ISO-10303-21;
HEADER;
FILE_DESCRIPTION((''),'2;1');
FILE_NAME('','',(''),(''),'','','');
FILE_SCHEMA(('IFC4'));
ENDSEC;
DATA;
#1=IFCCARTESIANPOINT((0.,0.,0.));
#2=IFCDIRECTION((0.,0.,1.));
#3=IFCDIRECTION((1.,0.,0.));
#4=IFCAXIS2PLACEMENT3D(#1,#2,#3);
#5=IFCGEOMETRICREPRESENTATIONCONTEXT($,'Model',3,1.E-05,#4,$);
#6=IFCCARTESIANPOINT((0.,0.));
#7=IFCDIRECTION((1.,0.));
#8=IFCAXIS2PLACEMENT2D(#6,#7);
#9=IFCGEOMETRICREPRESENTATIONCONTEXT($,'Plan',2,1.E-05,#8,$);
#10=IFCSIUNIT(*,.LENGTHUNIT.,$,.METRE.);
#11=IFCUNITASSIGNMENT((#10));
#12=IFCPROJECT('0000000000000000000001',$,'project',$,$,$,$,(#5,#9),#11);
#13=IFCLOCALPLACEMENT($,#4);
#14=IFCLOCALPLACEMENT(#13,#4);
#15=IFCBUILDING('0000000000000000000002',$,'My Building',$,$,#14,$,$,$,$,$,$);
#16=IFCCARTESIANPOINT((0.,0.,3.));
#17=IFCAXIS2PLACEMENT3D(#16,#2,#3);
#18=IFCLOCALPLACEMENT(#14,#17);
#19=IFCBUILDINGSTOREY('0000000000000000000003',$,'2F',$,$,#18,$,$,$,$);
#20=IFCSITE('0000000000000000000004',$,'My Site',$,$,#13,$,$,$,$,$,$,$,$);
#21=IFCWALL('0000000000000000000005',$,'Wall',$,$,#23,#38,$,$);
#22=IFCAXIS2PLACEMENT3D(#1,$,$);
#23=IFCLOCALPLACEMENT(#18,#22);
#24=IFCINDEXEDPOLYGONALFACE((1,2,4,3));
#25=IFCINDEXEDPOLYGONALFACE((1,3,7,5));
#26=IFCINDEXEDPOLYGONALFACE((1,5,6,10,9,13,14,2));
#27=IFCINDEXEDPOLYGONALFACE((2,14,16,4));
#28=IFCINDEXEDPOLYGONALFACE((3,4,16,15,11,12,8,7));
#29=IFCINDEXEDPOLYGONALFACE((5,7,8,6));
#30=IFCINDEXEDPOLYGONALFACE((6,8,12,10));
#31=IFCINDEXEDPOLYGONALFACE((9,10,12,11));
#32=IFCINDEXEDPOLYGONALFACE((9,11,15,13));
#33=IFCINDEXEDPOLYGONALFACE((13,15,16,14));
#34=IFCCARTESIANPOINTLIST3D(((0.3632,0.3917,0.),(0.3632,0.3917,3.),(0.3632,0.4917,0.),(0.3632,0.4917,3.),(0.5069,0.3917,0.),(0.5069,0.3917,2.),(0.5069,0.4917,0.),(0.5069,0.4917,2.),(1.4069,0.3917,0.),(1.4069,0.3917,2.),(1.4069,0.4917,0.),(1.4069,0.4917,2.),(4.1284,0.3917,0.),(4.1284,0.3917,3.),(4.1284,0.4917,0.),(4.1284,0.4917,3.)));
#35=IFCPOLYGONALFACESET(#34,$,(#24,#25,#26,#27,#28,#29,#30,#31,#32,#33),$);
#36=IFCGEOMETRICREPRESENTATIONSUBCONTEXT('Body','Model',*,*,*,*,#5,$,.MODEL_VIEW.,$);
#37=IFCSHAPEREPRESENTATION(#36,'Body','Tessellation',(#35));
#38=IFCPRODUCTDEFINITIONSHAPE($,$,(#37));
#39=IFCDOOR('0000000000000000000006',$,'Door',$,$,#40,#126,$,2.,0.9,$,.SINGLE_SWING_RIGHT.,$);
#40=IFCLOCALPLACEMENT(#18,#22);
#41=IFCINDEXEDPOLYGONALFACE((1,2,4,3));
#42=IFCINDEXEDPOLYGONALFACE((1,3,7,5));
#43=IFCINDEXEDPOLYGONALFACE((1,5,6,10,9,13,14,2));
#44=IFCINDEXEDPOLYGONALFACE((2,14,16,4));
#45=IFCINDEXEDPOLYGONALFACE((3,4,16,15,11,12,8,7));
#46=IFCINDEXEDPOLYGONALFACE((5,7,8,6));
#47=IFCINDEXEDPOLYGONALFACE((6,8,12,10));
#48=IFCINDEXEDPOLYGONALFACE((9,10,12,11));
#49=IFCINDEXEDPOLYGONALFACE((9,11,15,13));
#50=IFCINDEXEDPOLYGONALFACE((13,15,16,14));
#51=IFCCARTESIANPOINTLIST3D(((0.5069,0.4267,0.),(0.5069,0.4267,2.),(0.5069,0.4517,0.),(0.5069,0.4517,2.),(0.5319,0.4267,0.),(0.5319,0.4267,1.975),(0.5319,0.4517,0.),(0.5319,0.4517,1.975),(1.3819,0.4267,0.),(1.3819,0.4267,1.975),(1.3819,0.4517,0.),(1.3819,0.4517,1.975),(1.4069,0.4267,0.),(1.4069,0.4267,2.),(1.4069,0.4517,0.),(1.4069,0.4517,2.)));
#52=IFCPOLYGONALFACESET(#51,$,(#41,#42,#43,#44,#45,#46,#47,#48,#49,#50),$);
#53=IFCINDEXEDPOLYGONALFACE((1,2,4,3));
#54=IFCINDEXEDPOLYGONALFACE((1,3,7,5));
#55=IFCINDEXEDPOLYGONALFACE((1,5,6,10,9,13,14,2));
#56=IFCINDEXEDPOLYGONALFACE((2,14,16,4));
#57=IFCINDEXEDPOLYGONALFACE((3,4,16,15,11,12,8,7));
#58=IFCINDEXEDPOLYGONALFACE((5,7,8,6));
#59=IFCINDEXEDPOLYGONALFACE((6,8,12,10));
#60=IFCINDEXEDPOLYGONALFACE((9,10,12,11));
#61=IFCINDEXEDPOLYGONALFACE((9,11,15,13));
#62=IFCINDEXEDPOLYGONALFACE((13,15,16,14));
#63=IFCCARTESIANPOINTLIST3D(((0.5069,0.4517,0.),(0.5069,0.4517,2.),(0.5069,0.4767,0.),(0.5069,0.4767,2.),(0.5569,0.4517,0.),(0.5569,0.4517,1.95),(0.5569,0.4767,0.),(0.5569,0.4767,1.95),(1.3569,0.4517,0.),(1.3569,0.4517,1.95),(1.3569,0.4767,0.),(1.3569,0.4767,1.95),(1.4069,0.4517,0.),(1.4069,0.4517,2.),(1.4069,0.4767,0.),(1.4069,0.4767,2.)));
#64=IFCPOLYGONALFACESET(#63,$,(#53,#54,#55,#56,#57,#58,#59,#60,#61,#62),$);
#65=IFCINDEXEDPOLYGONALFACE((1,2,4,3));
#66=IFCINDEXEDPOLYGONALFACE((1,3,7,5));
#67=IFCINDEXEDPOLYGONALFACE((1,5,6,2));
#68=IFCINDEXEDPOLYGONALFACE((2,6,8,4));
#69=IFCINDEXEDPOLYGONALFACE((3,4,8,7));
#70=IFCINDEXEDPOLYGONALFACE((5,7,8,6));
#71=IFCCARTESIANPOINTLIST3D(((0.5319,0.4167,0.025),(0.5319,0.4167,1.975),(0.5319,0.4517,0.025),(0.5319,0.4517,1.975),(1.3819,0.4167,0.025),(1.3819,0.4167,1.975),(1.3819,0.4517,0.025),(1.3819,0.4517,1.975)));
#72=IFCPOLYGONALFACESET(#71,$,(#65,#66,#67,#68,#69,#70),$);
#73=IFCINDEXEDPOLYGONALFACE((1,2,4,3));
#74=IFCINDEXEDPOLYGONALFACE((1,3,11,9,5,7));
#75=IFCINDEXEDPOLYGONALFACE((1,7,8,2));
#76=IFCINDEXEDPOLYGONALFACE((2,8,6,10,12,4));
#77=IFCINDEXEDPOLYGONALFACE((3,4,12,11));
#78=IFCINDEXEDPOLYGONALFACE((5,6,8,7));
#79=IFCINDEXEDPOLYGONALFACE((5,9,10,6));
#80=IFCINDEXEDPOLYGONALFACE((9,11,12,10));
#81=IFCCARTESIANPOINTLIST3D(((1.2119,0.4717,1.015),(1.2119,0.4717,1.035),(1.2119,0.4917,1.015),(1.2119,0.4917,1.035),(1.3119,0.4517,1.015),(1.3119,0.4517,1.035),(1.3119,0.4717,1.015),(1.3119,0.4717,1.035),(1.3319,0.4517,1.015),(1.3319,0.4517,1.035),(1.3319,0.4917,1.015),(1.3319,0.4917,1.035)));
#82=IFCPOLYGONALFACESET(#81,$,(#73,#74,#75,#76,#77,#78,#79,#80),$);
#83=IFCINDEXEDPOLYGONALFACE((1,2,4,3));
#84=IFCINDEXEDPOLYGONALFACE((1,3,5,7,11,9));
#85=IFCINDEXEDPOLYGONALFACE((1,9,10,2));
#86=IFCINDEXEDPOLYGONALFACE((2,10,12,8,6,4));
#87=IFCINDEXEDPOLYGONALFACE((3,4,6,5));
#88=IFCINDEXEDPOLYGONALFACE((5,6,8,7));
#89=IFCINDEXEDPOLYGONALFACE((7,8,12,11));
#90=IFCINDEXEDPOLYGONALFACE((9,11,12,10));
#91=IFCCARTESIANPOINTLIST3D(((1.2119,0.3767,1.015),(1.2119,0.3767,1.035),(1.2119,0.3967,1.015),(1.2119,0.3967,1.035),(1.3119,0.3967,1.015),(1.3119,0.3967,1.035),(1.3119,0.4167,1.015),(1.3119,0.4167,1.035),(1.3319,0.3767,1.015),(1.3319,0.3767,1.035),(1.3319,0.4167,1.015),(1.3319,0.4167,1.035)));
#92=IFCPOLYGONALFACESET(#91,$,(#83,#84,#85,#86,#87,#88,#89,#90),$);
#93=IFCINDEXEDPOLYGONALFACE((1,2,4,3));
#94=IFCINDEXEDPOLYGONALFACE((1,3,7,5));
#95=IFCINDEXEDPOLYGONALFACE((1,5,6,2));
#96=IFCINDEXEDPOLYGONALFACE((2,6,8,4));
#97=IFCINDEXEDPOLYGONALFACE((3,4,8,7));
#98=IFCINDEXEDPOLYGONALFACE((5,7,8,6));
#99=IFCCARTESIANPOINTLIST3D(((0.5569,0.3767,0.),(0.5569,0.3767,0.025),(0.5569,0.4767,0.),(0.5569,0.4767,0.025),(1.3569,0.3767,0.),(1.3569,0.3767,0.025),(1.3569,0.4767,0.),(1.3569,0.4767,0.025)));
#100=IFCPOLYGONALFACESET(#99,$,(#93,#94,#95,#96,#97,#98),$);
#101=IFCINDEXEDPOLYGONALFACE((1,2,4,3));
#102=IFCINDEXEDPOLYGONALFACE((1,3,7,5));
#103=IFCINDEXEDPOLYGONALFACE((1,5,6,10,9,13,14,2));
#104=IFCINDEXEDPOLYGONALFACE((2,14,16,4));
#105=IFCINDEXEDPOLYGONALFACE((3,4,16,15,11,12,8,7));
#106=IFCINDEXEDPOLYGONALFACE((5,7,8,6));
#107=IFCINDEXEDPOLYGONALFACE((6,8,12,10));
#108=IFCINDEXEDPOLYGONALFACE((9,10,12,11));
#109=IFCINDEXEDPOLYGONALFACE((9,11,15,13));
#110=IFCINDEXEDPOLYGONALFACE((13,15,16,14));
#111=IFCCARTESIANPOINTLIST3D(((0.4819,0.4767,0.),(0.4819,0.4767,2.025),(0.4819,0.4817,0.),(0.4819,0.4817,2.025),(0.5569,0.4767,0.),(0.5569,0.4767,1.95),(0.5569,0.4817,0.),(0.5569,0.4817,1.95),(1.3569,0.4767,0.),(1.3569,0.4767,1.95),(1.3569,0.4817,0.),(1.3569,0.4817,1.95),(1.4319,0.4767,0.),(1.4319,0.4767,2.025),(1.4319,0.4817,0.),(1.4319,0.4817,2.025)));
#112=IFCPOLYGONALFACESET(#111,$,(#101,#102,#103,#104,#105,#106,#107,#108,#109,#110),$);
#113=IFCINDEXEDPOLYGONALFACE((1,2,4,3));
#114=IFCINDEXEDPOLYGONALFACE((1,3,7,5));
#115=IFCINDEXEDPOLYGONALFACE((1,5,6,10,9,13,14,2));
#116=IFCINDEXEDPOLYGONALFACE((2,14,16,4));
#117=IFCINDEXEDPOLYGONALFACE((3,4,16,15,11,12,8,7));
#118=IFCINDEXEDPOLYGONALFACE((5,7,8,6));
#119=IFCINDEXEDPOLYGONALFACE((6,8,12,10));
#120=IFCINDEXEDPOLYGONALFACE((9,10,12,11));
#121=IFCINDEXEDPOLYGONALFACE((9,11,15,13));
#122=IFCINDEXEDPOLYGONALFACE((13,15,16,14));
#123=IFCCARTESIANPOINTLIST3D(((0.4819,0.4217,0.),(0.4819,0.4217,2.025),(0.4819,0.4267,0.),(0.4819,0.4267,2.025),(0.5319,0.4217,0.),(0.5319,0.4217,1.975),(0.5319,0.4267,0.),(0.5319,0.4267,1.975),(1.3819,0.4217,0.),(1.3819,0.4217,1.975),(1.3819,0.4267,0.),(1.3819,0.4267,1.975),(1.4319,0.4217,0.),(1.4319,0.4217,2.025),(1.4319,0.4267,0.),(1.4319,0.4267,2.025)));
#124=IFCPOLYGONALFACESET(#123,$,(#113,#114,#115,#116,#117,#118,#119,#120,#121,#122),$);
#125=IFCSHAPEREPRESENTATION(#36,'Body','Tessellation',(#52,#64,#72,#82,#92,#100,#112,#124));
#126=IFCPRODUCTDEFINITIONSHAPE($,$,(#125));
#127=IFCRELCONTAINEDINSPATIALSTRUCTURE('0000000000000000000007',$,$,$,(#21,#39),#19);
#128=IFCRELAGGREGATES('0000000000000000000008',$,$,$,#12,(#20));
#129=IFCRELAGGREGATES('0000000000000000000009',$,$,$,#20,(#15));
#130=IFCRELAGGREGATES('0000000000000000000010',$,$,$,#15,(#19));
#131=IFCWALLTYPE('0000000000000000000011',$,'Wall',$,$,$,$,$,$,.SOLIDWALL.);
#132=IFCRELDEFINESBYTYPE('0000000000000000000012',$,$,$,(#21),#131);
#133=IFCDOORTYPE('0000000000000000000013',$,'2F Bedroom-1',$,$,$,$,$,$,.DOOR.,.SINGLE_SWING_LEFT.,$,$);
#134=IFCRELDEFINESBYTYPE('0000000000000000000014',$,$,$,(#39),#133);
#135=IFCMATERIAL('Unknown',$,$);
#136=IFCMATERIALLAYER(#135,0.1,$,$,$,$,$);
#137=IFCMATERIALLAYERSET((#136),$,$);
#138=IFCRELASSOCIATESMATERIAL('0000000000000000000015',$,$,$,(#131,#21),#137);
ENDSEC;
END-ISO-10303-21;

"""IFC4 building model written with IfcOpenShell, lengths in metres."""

from ifc_helpers import new_model, entity, si_unit, frame, origin_with_axes, origin_2d_with_axis, place, context, subcontext, project, spatial, line, indexed_curve, outline, extrude, shape, source, transform, mapped, material, layer, layer_set, layer_usage, type_object, type_shapes, element, fill, save


model = new_model("IFC4")

# Units and contexts
model_context_1 = context("Model", 3, precision=1e-05, world=origin_with_axes())
plan_context = context("Plan", 2, precision=1e-05, world=origin_2d_with_axis())
body_context_1 = subcontext(model_context_1, "Body", "Model", "MODEL_VIEW")
body_context_2 = subcontext(plan_context, "Body", "Plan", "PLAN_VIEW")
ifc_project = project(units=[si_unit("LENGTHUNIT", "METRE")], contexts=[model_context_1, plan_context])

# Site, building, storey
site_placement = place(None, origin_with_axes())
site = spatial("IfcSite", under=ifc_project, at=site_placement, Name="My Site")
building_placement = place(site_placement, origin_with_axes())
building = spatial("IfcBuilding", under=site, at=building_placement, Name="My Building")
storey_placement = place(building_placement, frame((0.0, 0.0, 3.0), z_axis=(0.0, 0.0, 1.0), x_axis=(1.0, 0.0, 0.0)))
storey = spatial("IfcBuildingStorey", under=building, at=storey_placement, Name="2F")

# Shared definitions
ifc_material = material(Name="Unknown")

# Shared definitions
ifc_layer_1 = layer(ifc_material, 0.1)
ifc_layer_set_1 = layer_set([ifc_layer_1])
wall_type = type_object("IfcWallType", Name="Wall", PredefinedType="SOLIDWALL", material=ifc_layer_set_1)

# Wall, opening, door
ifc_layer_usage_1 = layer_usage(ifc_layer_set_1, "AXIS2", "POSITIVE", 0.0)
wall_1_placement = place(storey_placement, frame((4.1284, 0.4917, 0.0), z_axis=(0.0, 0.0, 1.0), x_axis=(-1.0, 0.0, 0.0)))
wall_1 = element("IfcWall", 1, at=wall_1_placement, inside=storey, type_object=wall_type, material=ifc_layer_usage_1, Name="Wall", context=body_context_1, shape_type="SweptSolid", body=[
    extrude(outline(indexed_curve([(0.0, 0.0), (0.0, 0.1), (3.7652, 0.1), (3.7652, 0.0)], segments=[line(1, 2, 3, 4, 1)])), origin_with_axes(), (0.0, 0.0, 1.0), 3.0),
])
shared_shape_1 = source(origin_with_axes(), body_context_1, "Body", "SweptSolid", [
    extrude(outline(indexed_curve([(0.0, 0.0), (0.9, 0.0), (0.9, 2.0), (0.0, 2.0)], segments=[line(1, 2, 3, 4, 1)])), frame((0.0, -0.6, 0.0), z_axis=(0.0, -1.0, 0.0), x_axis=(1.0, 0.0, 0.0)), (0.0, 0.0, -1.0), 1.2),
])
opening_1_placement = place(wall_1_placement, frame((2.7215, 0.015, 0.0), z_axis=(0.0, 0.0, 1.0), x_axis=(1.0, 0.0, 0.0)))
opening_1 = element("IfcOpeningElement", 2, at=opening_1_placement, cuts=wall_1, PredefinedType="OPENING", context=body_context_1, shape_type="MappedRepresentation", body=[
    mapped(shared_shape_1, transform((0.0, 0.0, 0.0), x_axis=(1.0, 0.0, 0.0), y_axis=(0.0, 1.0, 0.0), z_axis=(0.0, 0.0, 1.0), scale=1.0)),
])
door_type_1 = type_object("IfcDoorType", Name="2F Bedroom-1", OperationType="SINGLE_SWING_LEFT", PredefinedType="DOOR")
shared_shape_2 = source(origin_with_axes(), body_context_1, "Body", "SweptSolid", [
    extrude(outline(indexed_curve([(0.0, 0.0), (0.0, 2.0), (0.9, 2.0), (0.9, 0.0), (0.875, 0.0), (0.875, 1.975), (0.025, 1.975), (0.025, 0.0)], segments=[line(1, 2, 3, 4, 5, 6, 7, 8, 1)])), frame((0.0, 0.025, 0.0), z_axis=(0.0, -1.0, 0.0), x_axis=(1.0, 0.0, 0.0)), (0.0, 0.0, -1.0), 0.025),
    extrude(outline(indexed_curve([(0.0, 0.0), (0.0, 2.0), (0.9, 2.0), (0.9, 0.0), (0.85, 0.0), (0.85, 1.95), (0.05, 1.95), (0.05, 0.0)], segments=[line(1, 2, 3, 4, 5, 6, 7, 8, 1)])), frame((0.0, 0.0, 0.0), z_axis=(0.0, -1.0, 0.0), x_axis=(1.0, 0.0, 0.0)), (0.0, 0.0, -1.0), 0.025),
    extrude(outline(indexed_curve([(0.0, 0.0), (0.85, 0.0), (0.85, 0.035), (0.0, 0.035)], segments=[line(1, 2, 3, 4, 1)])), frame((0.025, 0.025, 0.025), z_axis=(0.0, 0.0, 1.0), x_axis=(1.0, 0.0, 0.0)), (0.0, 0.0, 1.0), 1.95),
    extrude(outline(indexed_curve([(0.0, 0.0), (0.0, -0.04), (0.12, -0.04), (0.12, -0.02), (0.02, -0.02), (0.02, 0.0)], segments=[line(1, 2, 3, 4, 5, 6, 1)])), frame((0.075, 0.025, 1.015), z_axis=(0.0, 0.0, 1.0), x_axis=(1.0, 0.0, 0.0)), (0.0, 0.0, 1.0), 0.02),
    extrude(outline(indexed_curve([(0.0, 0.0), (0.0, 0.04), (0.12, 0.04), (0.12, 0.02), (0.02, 0.02), (0.02, 0.0)], segments=[line(1, 2, 3, 4, 5, 6, 1)])), frame((0.075, 0.06, 1.015), z_axis=(0.0, 0.0, 1.0), x_axis=(1.0, 0.0, 0.0)), (0.0, 0.0, 1.0), 0.02),
    extrude(outline(indexed_curve([(0.0, 0.0), (0.8, 0.0), (0.8, 0.1), (0.0, 0.1)], segments=[line(1, 2, 3, 4, 1)])), frame((0.05, 0.0, 0.0), z_axis=(0.0, 0.0, 1.0), x_axis=(1.0, 0.0, 0.0)), (0.0, 0.0, 1.0), 0.025),
    extrude(outline(indexed_curve([(0.0, 0.0), (0.0, 2.025), (0.95, 2.025), (0.95, 0.0), (0.875, 0.0), (0.875, 1.95), (0.075, 1.95), (0.075, 0.0)], segments=[line(1, 2, 3, 4, 5, 6, 7, 8, 1)])), frame((-0.025, -0.005, 0.0), z_axis=(0.0, -1.0, 0.0), x_axis=(1.0, 0.0, 0.0)), (0.0, 0.0, -1.0), 0.005),
    extrude(outline(indexed_curve([(0.0, 0.0), (0.0, 2.025), (0.95, 2.025), (0.95, 0.0), (0.9, 0.0), (0.9, 1.975), (0.05, 1.975), (0.05, 0.0)], segments=[line(1, 2, 3, 4, 5, 6, 7, 8, 1)])), frame((-0.025, 0.05, 0.0), z_axis=(0.0, -1.0, 0.0), x_axis=(1.0, 0.0, 0.0)), (0.0, 0.0, -1.0), 0.005),
])
shared_shape_3 = source(origin_with_axes(), body_context_2, "Body", "Curve2D", [
    entity("IfcIndexedPolyCurve", entity("IfcCartesianPointList2D", [[0.0, 0.0], [0.0, 0.05], [0.025, 0.05], [0.025, 0.025], [0.05, 0.025], [0.05, 0.0]]), [entity("IfcLineIndex", [1, 2, 3, 4, 5, 6, 1])]),
    entity("IfcIndexedPolyCurve", entity("IfcCartesianPointList2D", [[0.9, 0.0], [0.9, 0.05], [0.875, 0.05], [0.875, 0.025], [0.85, 0.025], [0.85, 0.0]]), [entity("IfcLineIndex", [1, 2, 3, 4, 5, 6, 1])]),
    entity("IfcTrimmedCurve", entity("IfcEllipse", entity("IfcAxis2Placement2D", entity("IfcCartesianPoint", [0.84, 0.05]), entity("IfcDirection", [1.0, 0.0])), 0.815, 0.85), [entity("IfcCartesianPoint", [0.84, 0.9])], [entity("IfcCartesianPoint", [0.025, 0.05])], True, "CARTESIAN"),
    entity("IfcIndexedPolyCurve", entity("IfcCartesianPointList2D", [[0.875, 0.05], [0.84, 0.05], [0.84, 0.9], [0.875, 0.9]]), [entity("IfcLineIndex", [1, 2, 3, 4, 1])]),
])
type_shapes(door_type_1, [shared_shape_2, shared_shape_3])
door_1_placement = place(opening_1_placement, frame((0.0, 0.0, 0.0), z_axis=(0.0, 0.0, 1.0), x_axis=(1.0, 0.0, 0.0)))
door_1 = element("IfcDoor", 3, at=door_1_placement, inside=storey, type_object=door_type_1, Name="Door", OperationType="SINGLE_SWING_RIGHT", OverallHeight=2.0, OverallWidth=0.9, shapes=[
    shape(body_context_1, "Body", "MappedRepresentation", [mapped(shared_shape_2, transform((0.0, 0.0, 0.0), x_axis=(1.0, 0.0, 0.0), y_axis=(0.0, 1.0, 0.0), z_axis=(0.0, 0.0, 1.0), scale=1.0))]),
    shape(body_context_2, "Body", "MappedRepresentation", [mapped(shared_shape_3, transform((0.0, 0.0, 0.0), x_axis=(1.0, 0.0, 0.0), y_axis=(0.0, 1.0, 0.0), z_axis=(0.0, 0.0, 1.0), scale=1.0))]),
])
fill(opening_1, door_1)

save(model, "model.ifc")
